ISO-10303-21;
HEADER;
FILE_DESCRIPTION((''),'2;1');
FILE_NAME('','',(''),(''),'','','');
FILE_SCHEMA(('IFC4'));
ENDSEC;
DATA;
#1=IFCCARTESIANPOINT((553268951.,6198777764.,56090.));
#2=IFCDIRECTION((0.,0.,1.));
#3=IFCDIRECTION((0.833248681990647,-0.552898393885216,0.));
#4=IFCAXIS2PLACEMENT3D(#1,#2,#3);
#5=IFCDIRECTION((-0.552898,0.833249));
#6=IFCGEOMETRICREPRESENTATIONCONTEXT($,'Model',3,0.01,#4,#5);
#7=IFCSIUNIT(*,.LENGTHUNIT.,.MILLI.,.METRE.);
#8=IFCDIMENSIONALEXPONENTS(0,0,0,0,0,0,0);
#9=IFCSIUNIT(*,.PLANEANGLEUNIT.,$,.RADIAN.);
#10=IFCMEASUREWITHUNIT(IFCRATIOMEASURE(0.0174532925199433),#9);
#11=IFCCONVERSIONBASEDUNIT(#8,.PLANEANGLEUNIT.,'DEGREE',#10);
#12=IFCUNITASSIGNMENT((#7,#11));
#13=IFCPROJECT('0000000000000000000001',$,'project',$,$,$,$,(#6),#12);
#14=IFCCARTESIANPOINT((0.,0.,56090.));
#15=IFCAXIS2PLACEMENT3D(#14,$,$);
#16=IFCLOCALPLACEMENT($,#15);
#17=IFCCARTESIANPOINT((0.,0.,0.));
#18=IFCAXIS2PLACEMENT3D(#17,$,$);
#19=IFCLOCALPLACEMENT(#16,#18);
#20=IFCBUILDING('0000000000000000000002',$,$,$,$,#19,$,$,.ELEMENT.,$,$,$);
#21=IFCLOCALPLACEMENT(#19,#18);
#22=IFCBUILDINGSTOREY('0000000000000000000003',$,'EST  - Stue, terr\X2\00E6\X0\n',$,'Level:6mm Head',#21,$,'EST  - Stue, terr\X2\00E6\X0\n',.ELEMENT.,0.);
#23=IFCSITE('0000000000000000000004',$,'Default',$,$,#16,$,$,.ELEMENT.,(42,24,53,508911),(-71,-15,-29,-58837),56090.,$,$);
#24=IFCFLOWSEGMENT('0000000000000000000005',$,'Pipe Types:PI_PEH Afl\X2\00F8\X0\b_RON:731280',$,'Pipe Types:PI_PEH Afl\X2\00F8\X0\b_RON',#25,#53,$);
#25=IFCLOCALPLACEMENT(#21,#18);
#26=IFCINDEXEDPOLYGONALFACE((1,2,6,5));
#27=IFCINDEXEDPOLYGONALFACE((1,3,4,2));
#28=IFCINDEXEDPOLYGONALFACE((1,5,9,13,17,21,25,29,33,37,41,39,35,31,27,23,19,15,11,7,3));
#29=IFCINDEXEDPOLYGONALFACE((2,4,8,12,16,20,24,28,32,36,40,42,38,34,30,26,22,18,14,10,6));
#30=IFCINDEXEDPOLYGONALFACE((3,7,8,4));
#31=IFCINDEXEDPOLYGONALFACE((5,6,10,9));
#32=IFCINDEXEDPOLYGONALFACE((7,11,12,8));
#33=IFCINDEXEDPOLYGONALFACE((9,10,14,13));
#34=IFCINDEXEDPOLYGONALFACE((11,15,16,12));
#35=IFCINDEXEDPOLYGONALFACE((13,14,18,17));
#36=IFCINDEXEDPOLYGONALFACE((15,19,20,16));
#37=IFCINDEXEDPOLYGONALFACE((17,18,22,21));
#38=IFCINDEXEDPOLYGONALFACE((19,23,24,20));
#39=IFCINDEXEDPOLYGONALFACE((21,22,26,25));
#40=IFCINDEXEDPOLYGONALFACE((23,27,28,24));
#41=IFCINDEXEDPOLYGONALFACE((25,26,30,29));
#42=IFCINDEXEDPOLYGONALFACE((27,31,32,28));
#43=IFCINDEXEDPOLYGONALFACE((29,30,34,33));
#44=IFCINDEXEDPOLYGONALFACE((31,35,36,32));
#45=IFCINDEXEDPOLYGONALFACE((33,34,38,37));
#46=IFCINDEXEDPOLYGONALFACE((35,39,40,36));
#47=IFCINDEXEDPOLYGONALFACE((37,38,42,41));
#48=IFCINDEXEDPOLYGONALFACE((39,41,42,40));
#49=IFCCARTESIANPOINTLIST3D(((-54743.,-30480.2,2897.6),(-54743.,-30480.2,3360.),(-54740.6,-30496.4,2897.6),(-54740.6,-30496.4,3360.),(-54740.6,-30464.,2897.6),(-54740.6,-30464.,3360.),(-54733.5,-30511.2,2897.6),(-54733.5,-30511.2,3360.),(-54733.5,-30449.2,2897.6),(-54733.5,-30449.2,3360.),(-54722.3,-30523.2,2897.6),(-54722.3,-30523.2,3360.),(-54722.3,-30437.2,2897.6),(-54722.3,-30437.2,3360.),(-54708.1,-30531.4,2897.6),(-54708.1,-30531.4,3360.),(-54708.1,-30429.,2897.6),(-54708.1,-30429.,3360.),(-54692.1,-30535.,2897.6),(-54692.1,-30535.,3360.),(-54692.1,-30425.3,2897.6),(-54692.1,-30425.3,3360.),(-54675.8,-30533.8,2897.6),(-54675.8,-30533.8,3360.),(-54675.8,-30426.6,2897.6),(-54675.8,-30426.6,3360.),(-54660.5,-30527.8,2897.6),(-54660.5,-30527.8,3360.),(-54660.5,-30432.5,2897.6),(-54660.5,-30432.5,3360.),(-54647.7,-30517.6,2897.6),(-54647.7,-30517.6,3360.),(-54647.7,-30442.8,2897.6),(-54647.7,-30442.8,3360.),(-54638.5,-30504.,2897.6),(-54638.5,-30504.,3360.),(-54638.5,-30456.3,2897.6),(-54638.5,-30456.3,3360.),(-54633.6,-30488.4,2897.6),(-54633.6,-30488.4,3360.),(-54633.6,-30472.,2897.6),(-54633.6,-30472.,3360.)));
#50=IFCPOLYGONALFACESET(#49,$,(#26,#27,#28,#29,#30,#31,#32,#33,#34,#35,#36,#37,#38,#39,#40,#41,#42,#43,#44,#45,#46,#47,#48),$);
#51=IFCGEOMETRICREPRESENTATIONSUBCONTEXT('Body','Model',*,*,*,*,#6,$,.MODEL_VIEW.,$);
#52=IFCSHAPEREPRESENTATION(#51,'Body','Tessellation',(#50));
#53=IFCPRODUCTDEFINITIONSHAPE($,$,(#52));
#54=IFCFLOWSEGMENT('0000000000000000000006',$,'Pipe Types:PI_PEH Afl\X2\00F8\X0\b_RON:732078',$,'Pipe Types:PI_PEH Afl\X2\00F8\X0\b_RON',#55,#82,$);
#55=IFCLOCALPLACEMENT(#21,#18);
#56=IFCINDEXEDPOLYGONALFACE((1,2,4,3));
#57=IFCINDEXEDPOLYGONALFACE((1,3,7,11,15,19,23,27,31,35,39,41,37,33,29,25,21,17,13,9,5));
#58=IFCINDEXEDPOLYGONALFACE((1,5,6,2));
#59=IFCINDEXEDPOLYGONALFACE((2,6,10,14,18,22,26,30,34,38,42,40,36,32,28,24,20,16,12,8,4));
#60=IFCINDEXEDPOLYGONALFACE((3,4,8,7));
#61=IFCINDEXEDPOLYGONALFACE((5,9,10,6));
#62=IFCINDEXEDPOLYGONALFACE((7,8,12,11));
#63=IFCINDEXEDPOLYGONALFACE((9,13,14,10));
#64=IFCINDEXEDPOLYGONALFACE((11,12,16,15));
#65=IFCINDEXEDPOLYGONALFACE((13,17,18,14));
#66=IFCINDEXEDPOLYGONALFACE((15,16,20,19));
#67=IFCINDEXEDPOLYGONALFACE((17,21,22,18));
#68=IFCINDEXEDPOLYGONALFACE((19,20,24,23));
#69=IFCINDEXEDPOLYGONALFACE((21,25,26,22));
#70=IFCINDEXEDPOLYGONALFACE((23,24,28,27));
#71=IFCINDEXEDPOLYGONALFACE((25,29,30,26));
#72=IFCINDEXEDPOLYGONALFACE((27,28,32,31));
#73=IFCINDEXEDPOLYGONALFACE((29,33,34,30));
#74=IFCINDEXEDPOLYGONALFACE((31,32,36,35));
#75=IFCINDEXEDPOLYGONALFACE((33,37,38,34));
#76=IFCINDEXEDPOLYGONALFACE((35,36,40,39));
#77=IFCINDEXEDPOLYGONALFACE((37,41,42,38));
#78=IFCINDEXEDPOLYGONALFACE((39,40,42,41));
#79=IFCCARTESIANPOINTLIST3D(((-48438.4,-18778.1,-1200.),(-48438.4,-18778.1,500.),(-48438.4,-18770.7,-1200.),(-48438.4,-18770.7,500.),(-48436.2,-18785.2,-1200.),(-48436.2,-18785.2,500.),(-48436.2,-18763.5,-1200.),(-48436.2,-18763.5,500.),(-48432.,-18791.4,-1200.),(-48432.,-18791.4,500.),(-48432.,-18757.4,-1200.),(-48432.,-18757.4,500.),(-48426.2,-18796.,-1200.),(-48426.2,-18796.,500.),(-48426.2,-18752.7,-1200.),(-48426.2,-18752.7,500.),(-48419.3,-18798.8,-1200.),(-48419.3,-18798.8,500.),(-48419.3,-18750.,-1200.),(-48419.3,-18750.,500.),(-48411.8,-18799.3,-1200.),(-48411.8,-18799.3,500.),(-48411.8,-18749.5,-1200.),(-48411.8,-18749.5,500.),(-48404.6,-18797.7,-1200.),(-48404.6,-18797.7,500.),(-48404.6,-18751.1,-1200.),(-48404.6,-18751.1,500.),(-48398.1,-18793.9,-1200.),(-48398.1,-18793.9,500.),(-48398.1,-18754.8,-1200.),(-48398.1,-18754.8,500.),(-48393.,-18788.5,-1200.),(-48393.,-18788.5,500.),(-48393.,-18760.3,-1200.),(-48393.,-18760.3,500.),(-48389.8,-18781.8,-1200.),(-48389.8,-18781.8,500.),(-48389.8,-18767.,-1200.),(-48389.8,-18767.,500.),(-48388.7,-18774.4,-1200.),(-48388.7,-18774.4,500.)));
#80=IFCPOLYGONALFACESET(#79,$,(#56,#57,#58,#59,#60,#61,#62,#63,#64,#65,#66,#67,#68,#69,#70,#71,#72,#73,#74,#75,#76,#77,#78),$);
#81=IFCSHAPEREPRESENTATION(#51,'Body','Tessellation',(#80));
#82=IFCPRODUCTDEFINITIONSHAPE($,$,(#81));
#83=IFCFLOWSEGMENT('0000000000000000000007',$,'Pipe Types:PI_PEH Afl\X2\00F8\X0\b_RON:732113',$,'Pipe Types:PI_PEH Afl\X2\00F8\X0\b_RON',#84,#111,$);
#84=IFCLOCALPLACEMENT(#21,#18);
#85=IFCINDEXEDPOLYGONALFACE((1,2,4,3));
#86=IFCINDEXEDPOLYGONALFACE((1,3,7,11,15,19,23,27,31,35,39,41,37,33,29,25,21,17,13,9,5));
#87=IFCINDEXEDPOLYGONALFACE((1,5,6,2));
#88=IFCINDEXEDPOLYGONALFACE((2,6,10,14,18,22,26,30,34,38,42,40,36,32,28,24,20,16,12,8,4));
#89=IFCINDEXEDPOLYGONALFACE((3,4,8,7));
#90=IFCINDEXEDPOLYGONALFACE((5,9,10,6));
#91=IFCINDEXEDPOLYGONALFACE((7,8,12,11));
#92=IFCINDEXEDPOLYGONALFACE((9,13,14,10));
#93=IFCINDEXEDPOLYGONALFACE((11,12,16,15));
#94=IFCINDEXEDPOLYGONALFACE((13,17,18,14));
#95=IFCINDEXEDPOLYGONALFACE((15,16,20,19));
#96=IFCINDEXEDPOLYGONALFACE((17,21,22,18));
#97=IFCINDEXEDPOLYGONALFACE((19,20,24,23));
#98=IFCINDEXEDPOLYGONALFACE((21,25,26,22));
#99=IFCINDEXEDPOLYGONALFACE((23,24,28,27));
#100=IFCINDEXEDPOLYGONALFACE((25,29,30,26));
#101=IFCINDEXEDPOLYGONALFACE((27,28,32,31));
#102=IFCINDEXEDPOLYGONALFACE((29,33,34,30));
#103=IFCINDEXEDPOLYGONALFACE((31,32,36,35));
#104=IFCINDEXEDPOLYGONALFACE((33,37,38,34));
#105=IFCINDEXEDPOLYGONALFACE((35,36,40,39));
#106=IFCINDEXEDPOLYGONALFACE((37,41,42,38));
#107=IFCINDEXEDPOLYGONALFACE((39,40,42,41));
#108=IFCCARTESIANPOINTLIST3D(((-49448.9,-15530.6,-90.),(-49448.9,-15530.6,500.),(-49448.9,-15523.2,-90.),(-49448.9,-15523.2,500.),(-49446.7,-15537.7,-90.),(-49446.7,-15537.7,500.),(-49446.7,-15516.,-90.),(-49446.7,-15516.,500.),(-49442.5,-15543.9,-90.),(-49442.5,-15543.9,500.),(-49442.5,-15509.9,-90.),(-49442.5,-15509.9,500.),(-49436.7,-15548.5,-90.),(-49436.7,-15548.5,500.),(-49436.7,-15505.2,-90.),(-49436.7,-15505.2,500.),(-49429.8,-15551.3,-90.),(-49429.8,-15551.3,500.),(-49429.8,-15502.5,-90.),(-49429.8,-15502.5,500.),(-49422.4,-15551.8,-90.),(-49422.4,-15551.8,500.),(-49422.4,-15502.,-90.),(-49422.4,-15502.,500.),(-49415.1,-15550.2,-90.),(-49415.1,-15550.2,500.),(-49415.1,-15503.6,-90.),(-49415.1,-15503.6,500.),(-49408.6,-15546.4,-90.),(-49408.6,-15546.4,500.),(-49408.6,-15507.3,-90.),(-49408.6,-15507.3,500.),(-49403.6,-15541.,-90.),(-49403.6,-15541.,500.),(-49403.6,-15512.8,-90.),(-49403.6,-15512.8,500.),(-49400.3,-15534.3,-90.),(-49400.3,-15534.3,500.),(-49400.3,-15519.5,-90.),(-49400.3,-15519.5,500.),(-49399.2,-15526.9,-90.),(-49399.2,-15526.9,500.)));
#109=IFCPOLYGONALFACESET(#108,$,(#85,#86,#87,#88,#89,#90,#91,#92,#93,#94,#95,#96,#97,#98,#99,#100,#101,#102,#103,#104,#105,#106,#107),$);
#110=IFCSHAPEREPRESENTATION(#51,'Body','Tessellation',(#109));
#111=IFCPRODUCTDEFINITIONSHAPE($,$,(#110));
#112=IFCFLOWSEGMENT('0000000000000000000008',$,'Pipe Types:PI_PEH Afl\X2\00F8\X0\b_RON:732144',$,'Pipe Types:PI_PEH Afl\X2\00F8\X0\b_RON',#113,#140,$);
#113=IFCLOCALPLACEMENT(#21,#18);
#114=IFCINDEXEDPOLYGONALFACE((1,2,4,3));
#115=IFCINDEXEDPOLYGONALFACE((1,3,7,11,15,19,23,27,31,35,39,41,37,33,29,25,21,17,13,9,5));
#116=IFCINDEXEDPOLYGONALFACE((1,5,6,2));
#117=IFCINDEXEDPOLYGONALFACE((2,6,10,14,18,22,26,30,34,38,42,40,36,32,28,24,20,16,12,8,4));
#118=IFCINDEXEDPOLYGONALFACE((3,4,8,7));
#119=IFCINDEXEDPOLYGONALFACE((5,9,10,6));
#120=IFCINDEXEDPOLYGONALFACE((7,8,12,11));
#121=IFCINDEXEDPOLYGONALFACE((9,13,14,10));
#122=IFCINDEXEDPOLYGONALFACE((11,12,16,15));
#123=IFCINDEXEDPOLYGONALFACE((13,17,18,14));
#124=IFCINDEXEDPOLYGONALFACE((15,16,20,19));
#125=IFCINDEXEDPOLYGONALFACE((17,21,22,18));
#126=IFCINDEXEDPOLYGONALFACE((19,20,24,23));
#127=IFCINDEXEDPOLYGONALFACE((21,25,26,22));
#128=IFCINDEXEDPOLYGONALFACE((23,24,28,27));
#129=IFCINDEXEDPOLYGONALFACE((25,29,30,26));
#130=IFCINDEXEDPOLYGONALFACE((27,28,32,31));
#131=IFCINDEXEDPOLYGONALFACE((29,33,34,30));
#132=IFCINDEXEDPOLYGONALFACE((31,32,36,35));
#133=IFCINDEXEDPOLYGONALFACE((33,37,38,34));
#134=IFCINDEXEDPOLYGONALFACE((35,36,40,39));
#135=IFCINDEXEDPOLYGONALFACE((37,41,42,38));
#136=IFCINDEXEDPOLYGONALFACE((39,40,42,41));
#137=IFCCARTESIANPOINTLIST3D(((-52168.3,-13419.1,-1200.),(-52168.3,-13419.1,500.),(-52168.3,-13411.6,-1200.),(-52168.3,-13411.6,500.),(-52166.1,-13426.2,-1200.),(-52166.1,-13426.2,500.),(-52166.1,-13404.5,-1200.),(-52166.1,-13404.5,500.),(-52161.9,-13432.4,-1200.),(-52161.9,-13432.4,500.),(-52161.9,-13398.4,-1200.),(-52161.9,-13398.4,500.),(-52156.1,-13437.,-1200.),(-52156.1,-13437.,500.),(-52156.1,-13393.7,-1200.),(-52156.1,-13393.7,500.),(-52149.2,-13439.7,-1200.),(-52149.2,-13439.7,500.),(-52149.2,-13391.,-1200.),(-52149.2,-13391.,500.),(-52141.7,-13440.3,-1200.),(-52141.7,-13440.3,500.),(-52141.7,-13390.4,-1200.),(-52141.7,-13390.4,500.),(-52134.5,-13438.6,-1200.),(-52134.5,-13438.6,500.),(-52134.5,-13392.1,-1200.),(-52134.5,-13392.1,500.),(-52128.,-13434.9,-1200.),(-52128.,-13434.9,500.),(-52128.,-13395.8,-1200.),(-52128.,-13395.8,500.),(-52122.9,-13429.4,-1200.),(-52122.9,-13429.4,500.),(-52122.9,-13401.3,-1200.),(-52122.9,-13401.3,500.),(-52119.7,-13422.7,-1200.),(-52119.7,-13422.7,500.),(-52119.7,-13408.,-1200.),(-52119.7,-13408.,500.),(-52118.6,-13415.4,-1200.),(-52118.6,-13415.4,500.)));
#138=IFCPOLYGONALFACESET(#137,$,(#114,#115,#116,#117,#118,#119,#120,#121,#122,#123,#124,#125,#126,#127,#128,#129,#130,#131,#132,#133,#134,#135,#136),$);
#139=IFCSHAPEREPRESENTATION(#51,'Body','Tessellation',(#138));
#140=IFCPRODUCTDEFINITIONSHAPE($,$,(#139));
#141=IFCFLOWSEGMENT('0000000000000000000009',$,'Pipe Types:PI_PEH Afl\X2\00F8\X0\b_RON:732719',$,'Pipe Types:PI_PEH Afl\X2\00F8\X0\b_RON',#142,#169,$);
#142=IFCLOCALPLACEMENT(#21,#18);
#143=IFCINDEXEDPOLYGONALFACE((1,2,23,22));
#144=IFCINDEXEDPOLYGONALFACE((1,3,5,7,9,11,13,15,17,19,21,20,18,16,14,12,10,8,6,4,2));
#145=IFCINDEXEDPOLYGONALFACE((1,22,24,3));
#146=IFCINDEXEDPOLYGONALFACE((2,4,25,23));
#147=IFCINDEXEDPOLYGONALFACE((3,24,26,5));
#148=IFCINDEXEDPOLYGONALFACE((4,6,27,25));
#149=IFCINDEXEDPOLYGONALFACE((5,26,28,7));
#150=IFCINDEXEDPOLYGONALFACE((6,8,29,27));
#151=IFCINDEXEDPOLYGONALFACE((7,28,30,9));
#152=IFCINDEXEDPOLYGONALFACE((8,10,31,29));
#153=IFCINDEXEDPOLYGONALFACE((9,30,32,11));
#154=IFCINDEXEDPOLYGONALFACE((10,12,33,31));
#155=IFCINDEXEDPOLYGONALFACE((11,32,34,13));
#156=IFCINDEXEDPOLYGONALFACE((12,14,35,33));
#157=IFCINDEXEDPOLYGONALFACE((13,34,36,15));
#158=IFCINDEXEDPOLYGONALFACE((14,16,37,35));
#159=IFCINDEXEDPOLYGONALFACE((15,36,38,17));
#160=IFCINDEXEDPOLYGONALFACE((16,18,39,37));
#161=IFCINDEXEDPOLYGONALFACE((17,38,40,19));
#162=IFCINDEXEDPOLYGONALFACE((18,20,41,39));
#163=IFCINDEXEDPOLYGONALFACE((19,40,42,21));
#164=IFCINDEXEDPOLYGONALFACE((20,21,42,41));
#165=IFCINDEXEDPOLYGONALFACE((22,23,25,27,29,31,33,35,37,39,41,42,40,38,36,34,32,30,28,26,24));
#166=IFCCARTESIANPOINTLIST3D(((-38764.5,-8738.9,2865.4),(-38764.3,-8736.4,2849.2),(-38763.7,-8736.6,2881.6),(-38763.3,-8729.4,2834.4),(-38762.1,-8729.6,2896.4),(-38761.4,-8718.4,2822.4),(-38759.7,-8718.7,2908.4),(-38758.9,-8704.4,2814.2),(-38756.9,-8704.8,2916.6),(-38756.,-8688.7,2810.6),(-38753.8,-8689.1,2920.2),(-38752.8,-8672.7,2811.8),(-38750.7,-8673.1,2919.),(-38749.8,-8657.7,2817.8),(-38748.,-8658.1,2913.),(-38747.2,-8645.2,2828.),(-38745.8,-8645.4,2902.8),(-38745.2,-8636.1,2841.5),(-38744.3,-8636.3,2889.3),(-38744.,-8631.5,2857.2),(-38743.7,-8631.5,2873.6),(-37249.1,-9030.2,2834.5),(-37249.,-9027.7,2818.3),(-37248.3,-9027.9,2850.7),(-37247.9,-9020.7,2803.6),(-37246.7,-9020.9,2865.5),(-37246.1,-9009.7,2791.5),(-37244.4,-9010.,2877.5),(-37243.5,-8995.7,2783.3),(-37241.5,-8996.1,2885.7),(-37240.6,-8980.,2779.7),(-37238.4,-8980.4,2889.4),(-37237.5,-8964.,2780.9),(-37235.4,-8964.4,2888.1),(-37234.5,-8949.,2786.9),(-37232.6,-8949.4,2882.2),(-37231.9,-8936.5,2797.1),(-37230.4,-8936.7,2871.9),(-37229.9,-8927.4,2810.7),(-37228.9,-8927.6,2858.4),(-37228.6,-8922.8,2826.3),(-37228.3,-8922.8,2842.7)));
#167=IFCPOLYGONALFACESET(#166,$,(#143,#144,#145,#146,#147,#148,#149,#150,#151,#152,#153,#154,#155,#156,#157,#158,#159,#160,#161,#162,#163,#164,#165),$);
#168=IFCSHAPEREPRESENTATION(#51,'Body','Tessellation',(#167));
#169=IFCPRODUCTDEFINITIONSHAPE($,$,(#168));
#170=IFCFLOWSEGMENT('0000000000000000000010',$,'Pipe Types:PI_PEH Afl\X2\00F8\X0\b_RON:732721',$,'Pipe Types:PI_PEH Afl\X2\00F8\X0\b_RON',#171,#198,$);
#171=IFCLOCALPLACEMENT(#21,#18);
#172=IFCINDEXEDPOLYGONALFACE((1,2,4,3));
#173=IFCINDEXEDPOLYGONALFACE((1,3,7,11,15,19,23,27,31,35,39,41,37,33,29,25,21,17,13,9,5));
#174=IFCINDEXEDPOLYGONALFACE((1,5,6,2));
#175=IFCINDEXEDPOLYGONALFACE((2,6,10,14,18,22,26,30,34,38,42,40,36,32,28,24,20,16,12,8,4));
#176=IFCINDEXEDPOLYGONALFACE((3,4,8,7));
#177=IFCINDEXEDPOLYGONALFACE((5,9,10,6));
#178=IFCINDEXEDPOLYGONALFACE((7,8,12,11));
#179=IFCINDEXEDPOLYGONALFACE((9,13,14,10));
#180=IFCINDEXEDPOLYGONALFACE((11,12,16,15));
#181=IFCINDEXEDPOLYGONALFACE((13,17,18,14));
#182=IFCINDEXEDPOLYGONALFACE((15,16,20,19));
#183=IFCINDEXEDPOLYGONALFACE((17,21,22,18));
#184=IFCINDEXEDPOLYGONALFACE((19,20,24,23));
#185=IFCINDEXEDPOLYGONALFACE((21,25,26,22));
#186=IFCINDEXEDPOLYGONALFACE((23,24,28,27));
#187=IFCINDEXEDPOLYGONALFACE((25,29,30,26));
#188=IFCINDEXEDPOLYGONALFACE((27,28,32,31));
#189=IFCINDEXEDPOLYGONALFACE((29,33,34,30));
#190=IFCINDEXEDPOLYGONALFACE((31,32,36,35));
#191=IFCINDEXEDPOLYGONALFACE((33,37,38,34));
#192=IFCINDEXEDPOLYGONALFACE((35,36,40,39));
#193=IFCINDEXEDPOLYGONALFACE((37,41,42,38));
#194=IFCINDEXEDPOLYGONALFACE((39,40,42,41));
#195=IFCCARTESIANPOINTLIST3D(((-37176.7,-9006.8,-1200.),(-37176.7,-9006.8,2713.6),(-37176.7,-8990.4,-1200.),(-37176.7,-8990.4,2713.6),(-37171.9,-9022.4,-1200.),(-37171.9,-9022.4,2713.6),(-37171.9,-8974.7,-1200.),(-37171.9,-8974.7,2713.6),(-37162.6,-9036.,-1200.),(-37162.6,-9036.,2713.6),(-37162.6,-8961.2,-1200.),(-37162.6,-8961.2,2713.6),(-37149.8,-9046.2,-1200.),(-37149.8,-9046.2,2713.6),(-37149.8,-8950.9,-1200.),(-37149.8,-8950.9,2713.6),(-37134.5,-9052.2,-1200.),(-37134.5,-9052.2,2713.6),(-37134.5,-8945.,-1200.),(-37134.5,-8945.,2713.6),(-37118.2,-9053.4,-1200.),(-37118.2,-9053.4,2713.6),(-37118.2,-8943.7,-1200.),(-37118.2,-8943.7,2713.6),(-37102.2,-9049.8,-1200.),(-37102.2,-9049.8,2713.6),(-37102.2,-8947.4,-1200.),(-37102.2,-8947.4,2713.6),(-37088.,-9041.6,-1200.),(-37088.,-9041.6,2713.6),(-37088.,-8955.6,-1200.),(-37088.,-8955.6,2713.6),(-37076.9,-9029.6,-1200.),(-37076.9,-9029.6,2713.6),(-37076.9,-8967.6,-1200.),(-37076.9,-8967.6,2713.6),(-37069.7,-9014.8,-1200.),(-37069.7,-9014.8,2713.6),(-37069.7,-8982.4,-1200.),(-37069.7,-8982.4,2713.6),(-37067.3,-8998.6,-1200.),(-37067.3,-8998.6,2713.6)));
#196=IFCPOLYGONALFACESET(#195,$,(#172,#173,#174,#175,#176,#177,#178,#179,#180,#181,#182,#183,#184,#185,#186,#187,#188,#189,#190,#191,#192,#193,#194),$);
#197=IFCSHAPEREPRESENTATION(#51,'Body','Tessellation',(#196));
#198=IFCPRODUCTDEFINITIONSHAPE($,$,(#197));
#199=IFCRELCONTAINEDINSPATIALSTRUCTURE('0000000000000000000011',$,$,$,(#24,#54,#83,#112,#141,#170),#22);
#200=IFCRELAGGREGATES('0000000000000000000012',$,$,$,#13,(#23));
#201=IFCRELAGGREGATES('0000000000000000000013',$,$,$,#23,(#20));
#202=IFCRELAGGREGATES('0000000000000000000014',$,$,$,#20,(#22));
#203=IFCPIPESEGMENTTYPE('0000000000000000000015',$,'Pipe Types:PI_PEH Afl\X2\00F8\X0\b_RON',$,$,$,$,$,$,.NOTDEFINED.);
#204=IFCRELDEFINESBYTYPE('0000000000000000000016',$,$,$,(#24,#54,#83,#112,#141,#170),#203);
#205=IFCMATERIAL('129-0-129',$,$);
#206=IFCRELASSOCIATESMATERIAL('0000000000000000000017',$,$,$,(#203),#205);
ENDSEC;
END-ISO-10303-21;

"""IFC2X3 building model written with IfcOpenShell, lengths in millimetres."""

from ifc_helpers import new_model, entity, si_unit, converted_unit, direction, frame, origin, origin_2d_with_axis, place, context, subcontext, project, spatial, circle, extrude, material, type_object, element, save


model = new_model("IFC2X3")

# Units and contexts
model_context = context("Model", 3, precision=0.01, world=frame((553268951.0, 6198777764.0, 56090.0), z_axis=(0.0, 0.0, 1.0), x_axis=(0.833248681990647, -0.552898393885216, 0.0)), true_north=direction((-0.552898, 0.833249)))
body_context = subcontext(model_context, "Body", "Model", "MODEL_VIEW")
ifc_project = project(units=[si_unit("LENGTHUNIT", "METRE", prefix="MILLI"), converted_unit("PLANEANGLEUNIT", "DEGREE", entity("IfcRatioMeasure", 0.0174532925199433), si_unit("PLANEANGLEUNIT", "RADIAN"), dimensions=[0, 0, 0, 0, 0, 0, 0])], contexts=[model_context])

# Site, building, storey
site_placement = place(None, frame((0.0, 0.0, 56090.0)))
site = spatial("IfcSite", under=ifc_project, at=site_placement, Name="Default", CompositionType="ELEMENT", RefLatitude=(42, 24, 53, 508911), RefLongitude=(-71, -15, -29, -58837), RefElevation=56090.0)
building_placement = place(site_placement, origin())
building = spatial("IfcBuilding", under=site, at=building_placement, CompositionType="ELEMENT")
storey_placement = place(building_placement, frame((0.0, 0.0, 0.0)))
storey = spatial("IfcBuildingStorey", under=building, at=storey_placement, Name="EST  - Stue, terræn", ObjectType="Level:6mm Head", LongName="EST  - Stue, terræn", CompositionType="ELEMENT", Elevation=0.0)

# Flow segments
ifc_material_1 = material(Name="129-0-129")
pipe_segment_type_1 = type_object("IfcPipeSegmentType", Name="Pipe Types:PI_PEH Afløb_RON", PredefinedType="NOTDEFINED", material=ifc_material_1)
flow_segment_1_placement = place(storey_placement, origin())
element("IfcFlowSegment", 1, at=flow_segment_1_placement, inside=storey, type_object=pipe_segment_type_1, Name="Pipe Types:PI_PEH Afløb_RON:731280", ObjectType="Pipe Types:PI_PEH Afløb_RON", context=body_context, shape_type="SweptSolid", body=[
    extrude(circle(Radius=55.0, at=origin_2d_with_axis()), frame((-54688.0, -30480.2, 2897.6), z_axis=(0.0, 0.0, 1.0), x_axis=(-1.0, 0.0, 0.0)), (0.0, 0.0, 1.0), 462.4),
])
flow_segment_2_placement = place(storey_placement, origin())
element("IfcFlowSegment", 2, at=flow_segment_2_placement, inside=storey, type_object=pipe_segment_type_1, Name="Pipe Types:PI_PEH Afløb_RON:732078", ObjectType="Pipe Types:PI_PEH Afløb_RON", context=body_context, shape_type="SweptSolid", body=[
    extrude(circle(Radius=25.0, at=origin_2d_with_axis()), frame((-48413.7, -18774.4, -1200.0)), (0.0, 0.0, 1.0), 1700.0),
])
flow_segment_3_placement = place(storey_placement, origin())
element("IfcFlowSegment", 3, at=flow_segment_3_placement, inside=storey, type_object=pipe_segment_type_1, Name="Pipe Types:PI_PEH Afløb_RON:732113", ObjectType="Pipe Types:PI_PEH Afløb_RON", context=body_context, shape_type="SweptSolid", body=[
    extrude(circle(Radius=25.0, at=origin_2d_with_axis()), frame((-49424.2, -15526.9, -90.0)), (0.0, 0.0, 1.0), 590.0),
])
flow_segment_4_placement = place(storey_placement, origin())
element("IfcFlowSegment", 4, at=flow_segment_4_placement, inside=storey, type_object=pipe_segment_type_1, Name="Pipe Types:PI_PEH Afløb_RON:732144", ObjectType="Pipe Types:PI_PEH Afløb_RON", context=body_context, shape_type="SweptSolid", body=[
    extrude(circle(Radius=25.0, at=origin_2d_with_axis()), frame((-52143.6, -13415.4, -1200.0)), (0.0, 0.0, 1.0), 1700.0),
])
flow_segment_5_placement = place(storey_placement, origin())
element("IfcFlowSegment", 5, at=flow_segment_5_placement, inside=storey, type_object=pipe_segment_type_1, Name="Pipe Types:PI_PEH Afløb_RON:732719", ObjectType="Pipe Types:PI_PEH Afløb_RON", context=body_context, shape_type="SweptSolid", body=[
    extrude(circle(Radius=55.0, at=origin_2d_with_axis()), frame((-38754.1, -8684.9, 2865.4), z_axis=(0.981824, -0.188737, -0.019996), x_axis=(-0.188775, -0.98202, 0.0)), (0.0, 0.0, 1.0), 1543.4),
])
flow_segment_6_placement = place(storey_placement, origin())
element("IfcFlowSegment", 6, at=flow_segment_6_placement, inside=storey, type_object=pipe_segment_type_1, Name="Pipe Types:PI_PEH Afløb_RON:732721", ObjectType="Pipe Types:PI_PEH Afløb_RON", context=body_context, shape_type="SweptSolid", body=[
    extrude(circle(Radius=55.0, at=origin_2d_with_axis()), frame((-37122.3, -8998.6, -1200.0)), (0.0, 0.0, 1.0), 3913.6),
])

save(model, "model.ifc")
